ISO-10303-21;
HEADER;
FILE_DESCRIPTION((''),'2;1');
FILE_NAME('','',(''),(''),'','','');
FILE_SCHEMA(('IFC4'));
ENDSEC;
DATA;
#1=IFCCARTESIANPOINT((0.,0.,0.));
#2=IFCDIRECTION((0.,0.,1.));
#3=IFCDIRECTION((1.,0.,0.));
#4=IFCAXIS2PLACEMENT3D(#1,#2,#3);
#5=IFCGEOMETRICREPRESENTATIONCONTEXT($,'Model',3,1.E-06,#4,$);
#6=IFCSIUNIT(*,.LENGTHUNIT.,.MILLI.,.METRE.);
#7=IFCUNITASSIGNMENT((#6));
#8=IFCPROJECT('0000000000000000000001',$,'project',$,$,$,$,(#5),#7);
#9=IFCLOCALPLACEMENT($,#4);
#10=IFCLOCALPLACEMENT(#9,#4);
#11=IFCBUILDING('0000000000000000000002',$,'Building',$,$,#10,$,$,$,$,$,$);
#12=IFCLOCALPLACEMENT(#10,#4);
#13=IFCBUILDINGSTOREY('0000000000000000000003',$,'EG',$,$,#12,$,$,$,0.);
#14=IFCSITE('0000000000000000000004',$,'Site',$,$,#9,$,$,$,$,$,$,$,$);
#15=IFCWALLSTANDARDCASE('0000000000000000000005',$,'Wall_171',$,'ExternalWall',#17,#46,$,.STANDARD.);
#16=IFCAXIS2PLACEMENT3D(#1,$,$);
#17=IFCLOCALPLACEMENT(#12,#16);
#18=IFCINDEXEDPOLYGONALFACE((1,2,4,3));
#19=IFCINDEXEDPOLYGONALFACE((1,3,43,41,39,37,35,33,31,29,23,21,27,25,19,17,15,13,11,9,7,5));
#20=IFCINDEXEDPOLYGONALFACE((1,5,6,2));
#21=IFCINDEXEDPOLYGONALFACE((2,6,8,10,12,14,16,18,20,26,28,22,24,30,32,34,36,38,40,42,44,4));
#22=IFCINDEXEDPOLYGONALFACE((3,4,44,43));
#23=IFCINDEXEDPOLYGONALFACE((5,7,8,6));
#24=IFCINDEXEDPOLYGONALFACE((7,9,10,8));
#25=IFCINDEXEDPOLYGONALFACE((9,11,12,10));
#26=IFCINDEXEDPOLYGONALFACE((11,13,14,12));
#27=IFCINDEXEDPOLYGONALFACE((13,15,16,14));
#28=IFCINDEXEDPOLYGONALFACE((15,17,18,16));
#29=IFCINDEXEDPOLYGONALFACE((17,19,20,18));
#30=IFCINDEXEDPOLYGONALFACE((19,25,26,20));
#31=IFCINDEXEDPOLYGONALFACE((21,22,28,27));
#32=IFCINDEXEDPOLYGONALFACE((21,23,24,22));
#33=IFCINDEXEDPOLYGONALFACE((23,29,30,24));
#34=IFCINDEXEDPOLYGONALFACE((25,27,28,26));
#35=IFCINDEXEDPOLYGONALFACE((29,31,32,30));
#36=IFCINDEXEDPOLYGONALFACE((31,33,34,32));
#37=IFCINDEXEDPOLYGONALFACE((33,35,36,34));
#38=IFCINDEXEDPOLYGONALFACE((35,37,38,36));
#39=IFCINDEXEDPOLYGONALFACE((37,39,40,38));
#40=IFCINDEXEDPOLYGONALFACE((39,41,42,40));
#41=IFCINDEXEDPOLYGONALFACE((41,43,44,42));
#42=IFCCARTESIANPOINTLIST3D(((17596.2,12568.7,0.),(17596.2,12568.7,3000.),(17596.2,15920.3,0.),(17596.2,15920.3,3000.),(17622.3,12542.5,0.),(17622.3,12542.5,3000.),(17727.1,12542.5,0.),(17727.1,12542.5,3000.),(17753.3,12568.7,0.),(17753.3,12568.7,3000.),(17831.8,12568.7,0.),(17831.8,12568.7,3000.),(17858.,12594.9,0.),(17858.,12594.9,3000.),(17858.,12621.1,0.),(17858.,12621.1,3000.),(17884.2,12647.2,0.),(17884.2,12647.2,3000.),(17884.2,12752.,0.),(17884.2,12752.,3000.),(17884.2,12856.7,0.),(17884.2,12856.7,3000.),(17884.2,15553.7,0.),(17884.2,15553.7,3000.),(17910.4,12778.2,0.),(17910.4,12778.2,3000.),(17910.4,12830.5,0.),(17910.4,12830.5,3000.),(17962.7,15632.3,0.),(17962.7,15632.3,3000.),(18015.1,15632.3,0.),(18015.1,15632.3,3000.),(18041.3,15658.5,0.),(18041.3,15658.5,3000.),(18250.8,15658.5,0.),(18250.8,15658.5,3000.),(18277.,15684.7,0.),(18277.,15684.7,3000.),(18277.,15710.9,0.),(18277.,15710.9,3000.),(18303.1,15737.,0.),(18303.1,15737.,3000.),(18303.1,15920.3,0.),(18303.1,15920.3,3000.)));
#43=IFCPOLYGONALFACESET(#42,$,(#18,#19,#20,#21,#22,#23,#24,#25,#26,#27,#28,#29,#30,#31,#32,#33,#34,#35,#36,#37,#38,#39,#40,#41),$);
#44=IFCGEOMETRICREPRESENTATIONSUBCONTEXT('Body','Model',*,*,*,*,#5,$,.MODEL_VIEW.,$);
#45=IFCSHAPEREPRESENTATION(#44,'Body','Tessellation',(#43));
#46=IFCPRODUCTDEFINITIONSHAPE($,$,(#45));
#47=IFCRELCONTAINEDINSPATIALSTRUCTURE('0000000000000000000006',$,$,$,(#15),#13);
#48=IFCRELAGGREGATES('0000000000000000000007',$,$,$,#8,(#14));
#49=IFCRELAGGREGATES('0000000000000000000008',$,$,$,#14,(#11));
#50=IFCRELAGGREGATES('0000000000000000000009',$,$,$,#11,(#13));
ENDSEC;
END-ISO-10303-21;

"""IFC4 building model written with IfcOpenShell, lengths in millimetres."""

from ifc_helpers import new_model, si_unit, frame, origin_with_axes, place, context, subcontext, project, spatial, polyline, outline, extrude, element, save


model = new_model("IFC4")

# Units and contexts
model_context = context("Model", 3, precision=1e-06, world=origin_with_axes())
body_context = subcontext(model_context, "Body", "Model", "MODEL_VIEW")
ifc_project = project(units=[si_unit("LENGTHUNIT", "METRE", prefix="MILLI")], contexts=[model_context])

# Site, building, storey
site_placement = place(None, origin_with_axes())
site = spatial("IfcSite", under=ifc_project, at=site_placement, Name="Site")
building_placement = place(site_placement, origin_with_axes())
building = spatial("IfcBuilding", under=site, at=building_placement, Name="Building")
storey_placement = place(building_placement, origin_with_axes())
storey = spatial("IfcBuildingStorey", under=building, at=storey_placement, Name="EG", Elevation=0.0)

# Wall
for number, where, z_axis, x_axis, name in (
    (1, (0.0, 0.0, 0.0), (0.0, 0.0, 1.0), (1.0, 0.0, 0.0), "Wall_171"),
):
    element("IfcWallStandardCase", number, at=place(storey_placement, frame(where, z_axis=z_axis, x_axis=x_axis)), inside=storey, Name=name, ObjectType="ExternalWall", PredefinedType="STANDARD", context=body_context, shape_type="SweptSolid", body=[
        extrude(outline(polyline([(17622.3, 12542.5, 0.0), (17596.2, 12568.7, 0.0), (17596.2, 15920.3, 0.0), (18303.1, 15920.3, 0.0), (18303.1, 15737.0, 0.0), (18277.0, 15710.9, 0.0), (18277.0, 15684.7, 0.0), (18250.8, 15658.5, 0.0), (18041.3, 15658.5, 0.0), (18015.1, 15632.3, 0.0), (17962.7, 15632.3, 0.0), (17884.2, 15553.7, 0.0), (17884.2, 12856.7, 0.0), (17910.4, 12830.5, 0.0), (17910.4, 12778.2, 0.0), (17884.2, 12752.0, 0.0), (17884.2, 12647.2, 0.0), (17858.0, 12621.1, 0.0), (17858.0, 12594.9, 0.0), (17831.8, 12568.7, 0.0), (17753.3, 12568.7, 0.0), (17727.1, 12542.5, 0.0), (17622.3, 12542.5, 0.0)])), origin_with_axes(), (0.0, 0.0, 1.0), 3000.0),
    ])

save(model, "model.ifc")
